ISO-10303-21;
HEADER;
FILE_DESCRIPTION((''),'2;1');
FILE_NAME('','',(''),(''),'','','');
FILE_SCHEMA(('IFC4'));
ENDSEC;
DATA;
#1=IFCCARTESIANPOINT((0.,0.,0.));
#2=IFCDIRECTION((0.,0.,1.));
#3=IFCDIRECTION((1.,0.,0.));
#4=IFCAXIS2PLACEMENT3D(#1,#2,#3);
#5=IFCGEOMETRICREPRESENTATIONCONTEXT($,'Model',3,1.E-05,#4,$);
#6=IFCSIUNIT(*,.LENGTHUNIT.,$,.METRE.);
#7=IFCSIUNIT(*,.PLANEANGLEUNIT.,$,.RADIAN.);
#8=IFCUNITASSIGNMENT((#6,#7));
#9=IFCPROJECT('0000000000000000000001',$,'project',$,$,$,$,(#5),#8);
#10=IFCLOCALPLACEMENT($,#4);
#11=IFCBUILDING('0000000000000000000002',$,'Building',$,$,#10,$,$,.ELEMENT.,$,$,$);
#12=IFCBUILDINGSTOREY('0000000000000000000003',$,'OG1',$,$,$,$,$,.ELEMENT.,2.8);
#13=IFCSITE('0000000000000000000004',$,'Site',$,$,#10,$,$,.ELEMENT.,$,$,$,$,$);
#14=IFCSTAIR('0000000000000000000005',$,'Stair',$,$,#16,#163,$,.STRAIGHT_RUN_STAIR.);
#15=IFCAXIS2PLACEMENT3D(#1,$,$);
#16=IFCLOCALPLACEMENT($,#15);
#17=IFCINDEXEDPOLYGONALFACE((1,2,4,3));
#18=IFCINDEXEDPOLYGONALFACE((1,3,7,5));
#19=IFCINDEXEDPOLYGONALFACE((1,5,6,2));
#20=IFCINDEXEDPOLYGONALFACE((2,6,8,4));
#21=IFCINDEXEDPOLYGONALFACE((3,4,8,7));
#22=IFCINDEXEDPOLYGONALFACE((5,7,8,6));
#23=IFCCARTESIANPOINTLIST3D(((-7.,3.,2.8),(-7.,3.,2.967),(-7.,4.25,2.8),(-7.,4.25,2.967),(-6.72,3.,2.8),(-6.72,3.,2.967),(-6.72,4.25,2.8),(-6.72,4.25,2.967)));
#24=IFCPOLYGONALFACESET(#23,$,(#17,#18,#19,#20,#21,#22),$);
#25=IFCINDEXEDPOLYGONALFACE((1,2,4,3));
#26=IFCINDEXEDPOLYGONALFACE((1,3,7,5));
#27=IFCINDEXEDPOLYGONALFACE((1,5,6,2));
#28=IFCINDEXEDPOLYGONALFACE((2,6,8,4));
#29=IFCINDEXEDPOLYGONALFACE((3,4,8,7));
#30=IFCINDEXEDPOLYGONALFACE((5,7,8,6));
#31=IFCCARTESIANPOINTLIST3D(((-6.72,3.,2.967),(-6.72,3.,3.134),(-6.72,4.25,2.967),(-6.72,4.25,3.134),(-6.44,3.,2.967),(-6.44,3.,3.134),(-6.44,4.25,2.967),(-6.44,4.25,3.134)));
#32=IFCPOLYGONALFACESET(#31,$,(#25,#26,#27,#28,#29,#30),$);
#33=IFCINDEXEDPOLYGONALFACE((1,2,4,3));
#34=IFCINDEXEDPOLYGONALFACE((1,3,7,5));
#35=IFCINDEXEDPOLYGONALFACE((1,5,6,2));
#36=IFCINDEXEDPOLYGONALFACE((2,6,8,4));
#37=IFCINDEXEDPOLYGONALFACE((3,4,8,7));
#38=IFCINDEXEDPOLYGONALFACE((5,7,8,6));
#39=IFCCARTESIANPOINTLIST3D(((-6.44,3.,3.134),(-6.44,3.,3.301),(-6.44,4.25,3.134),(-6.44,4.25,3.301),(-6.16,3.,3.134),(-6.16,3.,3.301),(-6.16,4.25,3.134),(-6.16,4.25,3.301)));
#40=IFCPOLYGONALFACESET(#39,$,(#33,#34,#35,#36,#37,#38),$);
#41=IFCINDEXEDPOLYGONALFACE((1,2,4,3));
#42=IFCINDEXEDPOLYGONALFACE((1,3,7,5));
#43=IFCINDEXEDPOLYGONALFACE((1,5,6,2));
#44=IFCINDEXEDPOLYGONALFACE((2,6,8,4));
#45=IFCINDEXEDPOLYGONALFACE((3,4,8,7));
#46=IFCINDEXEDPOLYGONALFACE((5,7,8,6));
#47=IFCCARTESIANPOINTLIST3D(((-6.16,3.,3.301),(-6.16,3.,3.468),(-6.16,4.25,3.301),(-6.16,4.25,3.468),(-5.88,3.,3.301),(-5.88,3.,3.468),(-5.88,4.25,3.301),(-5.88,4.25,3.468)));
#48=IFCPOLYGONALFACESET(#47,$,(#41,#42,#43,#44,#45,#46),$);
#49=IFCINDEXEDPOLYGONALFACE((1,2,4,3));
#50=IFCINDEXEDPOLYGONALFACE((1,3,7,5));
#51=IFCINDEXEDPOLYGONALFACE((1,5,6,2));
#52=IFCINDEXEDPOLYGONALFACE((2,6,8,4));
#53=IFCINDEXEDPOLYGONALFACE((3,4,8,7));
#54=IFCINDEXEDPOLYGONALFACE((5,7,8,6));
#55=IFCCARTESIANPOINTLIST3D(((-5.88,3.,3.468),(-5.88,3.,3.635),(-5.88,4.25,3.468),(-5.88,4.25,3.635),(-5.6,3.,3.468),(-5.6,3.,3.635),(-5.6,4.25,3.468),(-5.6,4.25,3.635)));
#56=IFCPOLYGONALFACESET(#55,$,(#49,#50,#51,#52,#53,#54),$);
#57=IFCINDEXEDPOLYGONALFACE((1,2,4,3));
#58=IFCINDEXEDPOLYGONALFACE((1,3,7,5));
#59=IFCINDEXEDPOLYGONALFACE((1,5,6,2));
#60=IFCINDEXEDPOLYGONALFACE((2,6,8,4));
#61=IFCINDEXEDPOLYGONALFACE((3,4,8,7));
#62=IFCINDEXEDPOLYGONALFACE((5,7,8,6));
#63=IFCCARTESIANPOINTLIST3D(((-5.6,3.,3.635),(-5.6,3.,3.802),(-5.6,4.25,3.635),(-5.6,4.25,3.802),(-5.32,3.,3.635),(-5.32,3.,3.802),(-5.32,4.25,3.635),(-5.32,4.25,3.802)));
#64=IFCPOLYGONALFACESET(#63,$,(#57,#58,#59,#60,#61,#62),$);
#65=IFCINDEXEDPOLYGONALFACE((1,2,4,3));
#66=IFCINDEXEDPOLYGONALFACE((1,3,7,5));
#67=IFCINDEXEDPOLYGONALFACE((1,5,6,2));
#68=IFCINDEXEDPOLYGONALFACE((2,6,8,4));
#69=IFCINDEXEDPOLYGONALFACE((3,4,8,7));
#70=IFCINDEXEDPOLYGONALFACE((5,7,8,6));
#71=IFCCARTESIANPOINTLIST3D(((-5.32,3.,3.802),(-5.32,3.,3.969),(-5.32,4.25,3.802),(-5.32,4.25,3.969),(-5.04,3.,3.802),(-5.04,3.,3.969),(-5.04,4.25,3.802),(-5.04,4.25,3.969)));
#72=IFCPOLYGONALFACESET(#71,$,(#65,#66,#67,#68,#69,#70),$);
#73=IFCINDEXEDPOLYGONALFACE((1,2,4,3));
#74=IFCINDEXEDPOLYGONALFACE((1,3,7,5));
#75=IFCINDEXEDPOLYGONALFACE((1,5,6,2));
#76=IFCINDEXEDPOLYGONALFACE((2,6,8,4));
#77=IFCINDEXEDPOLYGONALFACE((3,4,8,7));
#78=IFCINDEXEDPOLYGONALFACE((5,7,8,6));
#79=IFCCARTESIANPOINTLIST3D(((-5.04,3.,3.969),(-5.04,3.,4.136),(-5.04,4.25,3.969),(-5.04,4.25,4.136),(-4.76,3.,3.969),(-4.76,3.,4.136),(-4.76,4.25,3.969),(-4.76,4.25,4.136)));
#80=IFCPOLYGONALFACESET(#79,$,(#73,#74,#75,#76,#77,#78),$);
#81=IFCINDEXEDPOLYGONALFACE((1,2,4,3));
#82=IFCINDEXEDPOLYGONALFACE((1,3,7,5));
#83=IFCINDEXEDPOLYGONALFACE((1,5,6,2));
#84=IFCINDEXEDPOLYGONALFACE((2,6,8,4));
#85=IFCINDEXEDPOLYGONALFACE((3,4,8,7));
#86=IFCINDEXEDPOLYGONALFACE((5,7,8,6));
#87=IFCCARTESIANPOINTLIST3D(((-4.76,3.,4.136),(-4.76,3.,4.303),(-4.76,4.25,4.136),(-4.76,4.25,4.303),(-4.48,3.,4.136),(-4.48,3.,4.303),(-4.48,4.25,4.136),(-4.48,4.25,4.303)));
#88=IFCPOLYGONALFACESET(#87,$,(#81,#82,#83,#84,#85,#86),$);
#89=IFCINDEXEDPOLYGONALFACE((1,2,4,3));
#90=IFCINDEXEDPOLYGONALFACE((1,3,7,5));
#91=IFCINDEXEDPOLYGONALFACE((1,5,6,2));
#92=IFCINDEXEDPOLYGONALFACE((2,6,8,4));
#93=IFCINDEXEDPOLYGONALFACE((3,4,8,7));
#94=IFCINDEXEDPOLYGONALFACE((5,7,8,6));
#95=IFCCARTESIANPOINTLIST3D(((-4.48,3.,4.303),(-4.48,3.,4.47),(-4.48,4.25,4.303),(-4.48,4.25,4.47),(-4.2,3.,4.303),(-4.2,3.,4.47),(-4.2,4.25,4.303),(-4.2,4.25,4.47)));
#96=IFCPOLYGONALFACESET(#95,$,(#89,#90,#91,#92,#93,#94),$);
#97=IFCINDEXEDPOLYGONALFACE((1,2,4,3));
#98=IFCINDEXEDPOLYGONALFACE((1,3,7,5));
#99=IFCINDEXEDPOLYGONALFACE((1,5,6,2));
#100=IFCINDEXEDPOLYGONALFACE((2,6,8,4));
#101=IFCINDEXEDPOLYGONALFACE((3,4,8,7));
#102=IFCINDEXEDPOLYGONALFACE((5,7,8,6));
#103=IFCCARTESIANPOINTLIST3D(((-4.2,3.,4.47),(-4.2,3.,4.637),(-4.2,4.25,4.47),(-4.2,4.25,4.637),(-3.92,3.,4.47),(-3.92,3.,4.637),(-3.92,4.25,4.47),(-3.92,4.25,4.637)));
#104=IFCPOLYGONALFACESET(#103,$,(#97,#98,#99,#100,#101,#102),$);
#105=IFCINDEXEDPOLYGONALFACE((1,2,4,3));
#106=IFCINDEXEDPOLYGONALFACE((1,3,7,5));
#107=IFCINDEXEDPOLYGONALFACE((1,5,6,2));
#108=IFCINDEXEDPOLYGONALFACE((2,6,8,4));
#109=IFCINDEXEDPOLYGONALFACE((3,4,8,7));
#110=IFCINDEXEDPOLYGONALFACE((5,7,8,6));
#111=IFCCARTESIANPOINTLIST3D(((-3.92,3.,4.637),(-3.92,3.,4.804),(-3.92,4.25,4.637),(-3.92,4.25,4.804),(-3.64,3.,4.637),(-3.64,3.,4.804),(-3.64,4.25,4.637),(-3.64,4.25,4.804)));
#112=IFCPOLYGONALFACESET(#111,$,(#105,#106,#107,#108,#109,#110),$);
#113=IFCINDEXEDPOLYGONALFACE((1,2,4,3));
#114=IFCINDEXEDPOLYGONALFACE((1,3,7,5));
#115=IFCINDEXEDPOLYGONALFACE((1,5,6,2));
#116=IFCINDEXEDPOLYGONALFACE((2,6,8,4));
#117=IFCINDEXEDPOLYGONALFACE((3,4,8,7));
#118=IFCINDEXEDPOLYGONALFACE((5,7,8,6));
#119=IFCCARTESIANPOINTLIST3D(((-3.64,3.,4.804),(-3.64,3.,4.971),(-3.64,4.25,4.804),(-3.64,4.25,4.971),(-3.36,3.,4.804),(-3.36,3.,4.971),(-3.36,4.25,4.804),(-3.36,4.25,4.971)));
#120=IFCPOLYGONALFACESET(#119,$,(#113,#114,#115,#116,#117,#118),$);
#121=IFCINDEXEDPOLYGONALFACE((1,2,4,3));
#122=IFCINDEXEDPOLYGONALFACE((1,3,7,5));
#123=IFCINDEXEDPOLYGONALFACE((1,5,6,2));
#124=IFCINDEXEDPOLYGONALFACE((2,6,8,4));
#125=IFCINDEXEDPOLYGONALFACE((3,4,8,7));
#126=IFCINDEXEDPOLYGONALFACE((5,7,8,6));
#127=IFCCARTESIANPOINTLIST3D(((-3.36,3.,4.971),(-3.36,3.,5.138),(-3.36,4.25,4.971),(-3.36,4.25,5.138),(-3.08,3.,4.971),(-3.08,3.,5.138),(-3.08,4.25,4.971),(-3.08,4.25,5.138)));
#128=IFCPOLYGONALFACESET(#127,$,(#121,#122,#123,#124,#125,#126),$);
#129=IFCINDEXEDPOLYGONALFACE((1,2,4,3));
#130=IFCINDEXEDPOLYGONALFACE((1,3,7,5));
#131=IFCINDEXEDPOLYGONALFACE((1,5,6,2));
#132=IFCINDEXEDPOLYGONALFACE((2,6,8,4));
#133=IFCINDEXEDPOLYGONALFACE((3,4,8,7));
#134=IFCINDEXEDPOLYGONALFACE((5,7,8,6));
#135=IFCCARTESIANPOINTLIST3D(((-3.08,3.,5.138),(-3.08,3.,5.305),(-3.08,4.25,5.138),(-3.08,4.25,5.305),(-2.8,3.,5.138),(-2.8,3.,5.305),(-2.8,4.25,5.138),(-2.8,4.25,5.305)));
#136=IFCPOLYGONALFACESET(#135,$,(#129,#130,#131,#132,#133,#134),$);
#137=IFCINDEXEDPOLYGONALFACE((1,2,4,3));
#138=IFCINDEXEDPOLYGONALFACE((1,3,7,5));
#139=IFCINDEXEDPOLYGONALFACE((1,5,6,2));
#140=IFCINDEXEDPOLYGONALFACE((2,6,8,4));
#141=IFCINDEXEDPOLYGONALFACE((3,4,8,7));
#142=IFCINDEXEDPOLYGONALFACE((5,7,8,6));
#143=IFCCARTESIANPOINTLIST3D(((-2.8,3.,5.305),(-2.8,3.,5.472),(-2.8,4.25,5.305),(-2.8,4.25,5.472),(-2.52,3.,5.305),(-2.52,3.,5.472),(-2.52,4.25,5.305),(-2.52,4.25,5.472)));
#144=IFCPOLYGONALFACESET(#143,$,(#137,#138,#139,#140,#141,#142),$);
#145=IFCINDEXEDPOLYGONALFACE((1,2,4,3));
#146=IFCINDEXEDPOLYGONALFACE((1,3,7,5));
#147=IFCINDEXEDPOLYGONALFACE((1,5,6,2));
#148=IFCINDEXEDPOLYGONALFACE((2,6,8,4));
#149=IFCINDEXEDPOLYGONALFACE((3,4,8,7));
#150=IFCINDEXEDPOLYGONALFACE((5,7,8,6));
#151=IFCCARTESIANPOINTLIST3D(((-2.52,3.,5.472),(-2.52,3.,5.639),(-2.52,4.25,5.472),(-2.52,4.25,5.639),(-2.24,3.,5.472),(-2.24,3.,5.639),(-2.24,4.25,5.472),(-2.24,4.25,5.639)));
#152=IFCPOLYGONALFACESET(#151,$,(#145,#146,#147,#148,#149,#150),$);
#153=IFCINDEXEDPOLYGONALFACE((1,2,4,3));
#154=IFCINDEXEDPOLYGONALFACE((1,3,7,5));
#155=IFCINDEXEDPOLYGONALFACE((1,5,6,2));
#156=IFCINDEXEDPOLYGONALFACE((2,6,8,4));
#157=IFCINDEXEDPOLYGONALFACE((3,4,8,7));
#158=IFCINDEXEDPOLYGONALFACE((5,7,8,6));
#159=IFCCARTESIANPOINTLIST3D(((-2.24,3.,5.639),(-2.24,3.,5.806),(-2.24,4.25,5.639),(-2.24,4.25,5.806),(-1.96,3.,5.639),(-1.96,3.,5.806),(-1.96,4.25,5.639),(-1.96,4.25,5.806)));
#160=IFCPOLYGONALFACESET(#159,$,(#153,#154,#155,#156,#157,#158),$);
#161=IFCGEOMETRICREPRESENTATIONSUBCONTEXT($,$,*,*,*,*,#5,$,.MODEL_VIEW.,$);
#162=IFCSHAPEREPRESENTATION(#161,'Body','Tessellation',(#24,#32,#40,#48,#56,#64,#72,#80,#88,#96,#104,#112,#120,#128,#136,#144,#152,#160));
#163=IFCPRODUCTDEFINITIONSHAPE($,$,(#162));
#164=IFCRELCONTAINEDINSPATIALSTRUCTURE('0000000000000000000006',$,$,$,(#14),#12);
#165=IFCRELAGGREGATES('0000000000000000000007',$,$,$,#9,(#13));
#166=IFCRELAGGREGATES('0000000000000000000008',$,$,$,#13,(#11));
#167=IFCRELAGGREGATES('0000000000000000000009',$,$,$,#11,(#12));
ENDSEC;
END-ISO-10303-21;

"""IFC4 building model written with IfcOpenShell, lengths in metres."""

from ifc_helpers import new_model, si_unit, frame, frame_2d, origin, origin_with_axes, place, context, subcontext, project, spatial, rectangle, extrude, element, save


model = new_model("IFC4")

# Units and contexts
model_context = context("Model", 3, precision=1e-05, world=origin_with_axes())
sub_context = subcontext(model_context, None, None, "MODEL_VIEW")
ifc_project = project(units=[si_unit("LENGTHUNIT", "METRE"), si_unit("PLANEANGLEUNIT", "RADIAN")], contexts=[model_context])

# Site, building, storey
placement_1 = place(None, origin_with_axes())
site = spatial("IfcSite", under=ifc_project, at=placement_1, Name="Site", CompositionType="ELEMENT")
building = spatial("IfcBuilding", under=site, at=placement_1, Name="Building", CompositionType="ELEMENT")
storey = spatial("IfcBuildingStorey", under=building, Name="OG1", CompositionType="ELEMENT", Elevation=2.8)

# Stair
placement_2 = place(None, origin_with_axes())
placement_3 = place(placement_2, frame((0.0, 0.0, 2.8)))
stair_placement = place(placement_3, frame((-7.0, 3.0, 0.0)))
element("IfcStair", 1, at=stair_placement, inside=storey, Name="Stair", PredefinedType="STRAIGHT_RUN_STAIR", context=sub_context, shape_type="SolidModel", body=[
    extrude(rectangle(XDim=0.28, YDim=1.25, at=frame_2d((0.14, 0.625))), origin(), (0.0, 0.0, 1.0), 0.167),
    extrude(rectangle(XDim=0.28, YDim=1.25, at=frame_2d((0.14, 0.625))), frame((0.28, 0.0, 0.167)), (0.0, 0.0, 1.0), 0.167),
    extrude(rectangle(XDim=0.28, YDim=1.25, at=frame_2d((0.14, 0.625))), frame((0.56, 0.0, 0.334)), (0.0, 0.0, 1.0), 0.167),
    extrude(rectangle(XDim=0.28, YDim=1.25, at=frame_2d((0.14, 0.625))), frame((0.84, 0.0, 0.501)), (0.0, 0.0, 1.0), 0.167),
    extrude(rectangle(XDim=0.28, YDim=1.25, at=frame_2d((0.14, 0.625))), frame((1.12, 0.0, 0.668)), (0.0, 0.0, 1.0), 0.167),
    extrude(rectangle(XDim=0.28, YDim=1.25, at=frame_2d((0.14, 0.625))), frame((1.4, 0.0, 0.835)), (0.0, 0.0, 1.0), 0.167),
    extrude(rectangle(XDim=0.28, YDim=1.25, at=frame_2d((0.14, 0.625))), frame((1.68, 0.0, 1.002)), (0.0, 0.0, 1.0), 0.167),
    extrude(rectangle(XDim=0.28, YDim=1.25, at=frame_2d((0.14, 0.625))), frame((1.96, 0.0, 1.169)), (0.0, 0.0, 1.0), 0.167),
    extrude(rectangle(XDim=0.28, YDim=1.25, at=frame_2d((0.14, 0.625))), frame((2.24, 0.0, 1.336)), (0.0, 0.0, 1.0), 0.167),
    extrude(rectangle(XDim=0.28, YDim=1.25, at=frame_2d((0.14, 0.625))), frame((2.52, 0.0, 1.503)), (0.0, 0.0, 1.0), 0.167),
    extrude(rectangle(XDim=0.28, YDim=1.25, at=frame_2d((0.14, 0.625))), frame((2.8, 0.0, 1.67)), (0.0, 0.0, 1.0), 0.167),
    extrude(rectangle(XDim=0.28, YDim=1.25, at=frame_2d((0.14, 0.625))), frame((3.08, 0.0, 1.837)), (0.0, 0.0, 1.0), 0.167),
    extrude(rectangle(XDim=0.28, YDim=1.25, at=frame_2d((0.14, 0.625))), frame((3.36, 0.0, 2.004)), (0.0, 0.0, 1.0), 0.167),
    extrude(rectangle(XDim=0.28, YDim=1.25, at=frame_2d((0.14, 0.625))), frame((3.64, 0.0, 2.171)), (0.0, 0.0, 1.0), 0.167),
    extrude(rectangle(XDim=0.28, YDim=1.25, at=frame_2d((0.14, 0.625))), frame((3.92, 0.0, 2.338)), (0.0, 0.0, 1.0), 0.167),
    extrude(rectangle(XDim=0.28, YDim=1.25, at=frame_2d((0.14, 0.625))), frame((4.2, 0.0, 2.505)), (0.0, 0.0, 1.0), 0.167),
    extrude(rectangle(XDim=0.28, YDim=1.25, at=frame_2d((0.14, 0.625))), frame((4.48, 0.0, 2.672)), (0.0, 0.0, 1.0), 0.167),
    extrude(rectangle(XDim=0.28, YDim=1.25, at=frame_2d((0.14, 0.625))), frame((4.76, 0.0, 2.839)), (0.0, 0.0, 1.0), 0.167),
])

save(model, "model.ifc")
